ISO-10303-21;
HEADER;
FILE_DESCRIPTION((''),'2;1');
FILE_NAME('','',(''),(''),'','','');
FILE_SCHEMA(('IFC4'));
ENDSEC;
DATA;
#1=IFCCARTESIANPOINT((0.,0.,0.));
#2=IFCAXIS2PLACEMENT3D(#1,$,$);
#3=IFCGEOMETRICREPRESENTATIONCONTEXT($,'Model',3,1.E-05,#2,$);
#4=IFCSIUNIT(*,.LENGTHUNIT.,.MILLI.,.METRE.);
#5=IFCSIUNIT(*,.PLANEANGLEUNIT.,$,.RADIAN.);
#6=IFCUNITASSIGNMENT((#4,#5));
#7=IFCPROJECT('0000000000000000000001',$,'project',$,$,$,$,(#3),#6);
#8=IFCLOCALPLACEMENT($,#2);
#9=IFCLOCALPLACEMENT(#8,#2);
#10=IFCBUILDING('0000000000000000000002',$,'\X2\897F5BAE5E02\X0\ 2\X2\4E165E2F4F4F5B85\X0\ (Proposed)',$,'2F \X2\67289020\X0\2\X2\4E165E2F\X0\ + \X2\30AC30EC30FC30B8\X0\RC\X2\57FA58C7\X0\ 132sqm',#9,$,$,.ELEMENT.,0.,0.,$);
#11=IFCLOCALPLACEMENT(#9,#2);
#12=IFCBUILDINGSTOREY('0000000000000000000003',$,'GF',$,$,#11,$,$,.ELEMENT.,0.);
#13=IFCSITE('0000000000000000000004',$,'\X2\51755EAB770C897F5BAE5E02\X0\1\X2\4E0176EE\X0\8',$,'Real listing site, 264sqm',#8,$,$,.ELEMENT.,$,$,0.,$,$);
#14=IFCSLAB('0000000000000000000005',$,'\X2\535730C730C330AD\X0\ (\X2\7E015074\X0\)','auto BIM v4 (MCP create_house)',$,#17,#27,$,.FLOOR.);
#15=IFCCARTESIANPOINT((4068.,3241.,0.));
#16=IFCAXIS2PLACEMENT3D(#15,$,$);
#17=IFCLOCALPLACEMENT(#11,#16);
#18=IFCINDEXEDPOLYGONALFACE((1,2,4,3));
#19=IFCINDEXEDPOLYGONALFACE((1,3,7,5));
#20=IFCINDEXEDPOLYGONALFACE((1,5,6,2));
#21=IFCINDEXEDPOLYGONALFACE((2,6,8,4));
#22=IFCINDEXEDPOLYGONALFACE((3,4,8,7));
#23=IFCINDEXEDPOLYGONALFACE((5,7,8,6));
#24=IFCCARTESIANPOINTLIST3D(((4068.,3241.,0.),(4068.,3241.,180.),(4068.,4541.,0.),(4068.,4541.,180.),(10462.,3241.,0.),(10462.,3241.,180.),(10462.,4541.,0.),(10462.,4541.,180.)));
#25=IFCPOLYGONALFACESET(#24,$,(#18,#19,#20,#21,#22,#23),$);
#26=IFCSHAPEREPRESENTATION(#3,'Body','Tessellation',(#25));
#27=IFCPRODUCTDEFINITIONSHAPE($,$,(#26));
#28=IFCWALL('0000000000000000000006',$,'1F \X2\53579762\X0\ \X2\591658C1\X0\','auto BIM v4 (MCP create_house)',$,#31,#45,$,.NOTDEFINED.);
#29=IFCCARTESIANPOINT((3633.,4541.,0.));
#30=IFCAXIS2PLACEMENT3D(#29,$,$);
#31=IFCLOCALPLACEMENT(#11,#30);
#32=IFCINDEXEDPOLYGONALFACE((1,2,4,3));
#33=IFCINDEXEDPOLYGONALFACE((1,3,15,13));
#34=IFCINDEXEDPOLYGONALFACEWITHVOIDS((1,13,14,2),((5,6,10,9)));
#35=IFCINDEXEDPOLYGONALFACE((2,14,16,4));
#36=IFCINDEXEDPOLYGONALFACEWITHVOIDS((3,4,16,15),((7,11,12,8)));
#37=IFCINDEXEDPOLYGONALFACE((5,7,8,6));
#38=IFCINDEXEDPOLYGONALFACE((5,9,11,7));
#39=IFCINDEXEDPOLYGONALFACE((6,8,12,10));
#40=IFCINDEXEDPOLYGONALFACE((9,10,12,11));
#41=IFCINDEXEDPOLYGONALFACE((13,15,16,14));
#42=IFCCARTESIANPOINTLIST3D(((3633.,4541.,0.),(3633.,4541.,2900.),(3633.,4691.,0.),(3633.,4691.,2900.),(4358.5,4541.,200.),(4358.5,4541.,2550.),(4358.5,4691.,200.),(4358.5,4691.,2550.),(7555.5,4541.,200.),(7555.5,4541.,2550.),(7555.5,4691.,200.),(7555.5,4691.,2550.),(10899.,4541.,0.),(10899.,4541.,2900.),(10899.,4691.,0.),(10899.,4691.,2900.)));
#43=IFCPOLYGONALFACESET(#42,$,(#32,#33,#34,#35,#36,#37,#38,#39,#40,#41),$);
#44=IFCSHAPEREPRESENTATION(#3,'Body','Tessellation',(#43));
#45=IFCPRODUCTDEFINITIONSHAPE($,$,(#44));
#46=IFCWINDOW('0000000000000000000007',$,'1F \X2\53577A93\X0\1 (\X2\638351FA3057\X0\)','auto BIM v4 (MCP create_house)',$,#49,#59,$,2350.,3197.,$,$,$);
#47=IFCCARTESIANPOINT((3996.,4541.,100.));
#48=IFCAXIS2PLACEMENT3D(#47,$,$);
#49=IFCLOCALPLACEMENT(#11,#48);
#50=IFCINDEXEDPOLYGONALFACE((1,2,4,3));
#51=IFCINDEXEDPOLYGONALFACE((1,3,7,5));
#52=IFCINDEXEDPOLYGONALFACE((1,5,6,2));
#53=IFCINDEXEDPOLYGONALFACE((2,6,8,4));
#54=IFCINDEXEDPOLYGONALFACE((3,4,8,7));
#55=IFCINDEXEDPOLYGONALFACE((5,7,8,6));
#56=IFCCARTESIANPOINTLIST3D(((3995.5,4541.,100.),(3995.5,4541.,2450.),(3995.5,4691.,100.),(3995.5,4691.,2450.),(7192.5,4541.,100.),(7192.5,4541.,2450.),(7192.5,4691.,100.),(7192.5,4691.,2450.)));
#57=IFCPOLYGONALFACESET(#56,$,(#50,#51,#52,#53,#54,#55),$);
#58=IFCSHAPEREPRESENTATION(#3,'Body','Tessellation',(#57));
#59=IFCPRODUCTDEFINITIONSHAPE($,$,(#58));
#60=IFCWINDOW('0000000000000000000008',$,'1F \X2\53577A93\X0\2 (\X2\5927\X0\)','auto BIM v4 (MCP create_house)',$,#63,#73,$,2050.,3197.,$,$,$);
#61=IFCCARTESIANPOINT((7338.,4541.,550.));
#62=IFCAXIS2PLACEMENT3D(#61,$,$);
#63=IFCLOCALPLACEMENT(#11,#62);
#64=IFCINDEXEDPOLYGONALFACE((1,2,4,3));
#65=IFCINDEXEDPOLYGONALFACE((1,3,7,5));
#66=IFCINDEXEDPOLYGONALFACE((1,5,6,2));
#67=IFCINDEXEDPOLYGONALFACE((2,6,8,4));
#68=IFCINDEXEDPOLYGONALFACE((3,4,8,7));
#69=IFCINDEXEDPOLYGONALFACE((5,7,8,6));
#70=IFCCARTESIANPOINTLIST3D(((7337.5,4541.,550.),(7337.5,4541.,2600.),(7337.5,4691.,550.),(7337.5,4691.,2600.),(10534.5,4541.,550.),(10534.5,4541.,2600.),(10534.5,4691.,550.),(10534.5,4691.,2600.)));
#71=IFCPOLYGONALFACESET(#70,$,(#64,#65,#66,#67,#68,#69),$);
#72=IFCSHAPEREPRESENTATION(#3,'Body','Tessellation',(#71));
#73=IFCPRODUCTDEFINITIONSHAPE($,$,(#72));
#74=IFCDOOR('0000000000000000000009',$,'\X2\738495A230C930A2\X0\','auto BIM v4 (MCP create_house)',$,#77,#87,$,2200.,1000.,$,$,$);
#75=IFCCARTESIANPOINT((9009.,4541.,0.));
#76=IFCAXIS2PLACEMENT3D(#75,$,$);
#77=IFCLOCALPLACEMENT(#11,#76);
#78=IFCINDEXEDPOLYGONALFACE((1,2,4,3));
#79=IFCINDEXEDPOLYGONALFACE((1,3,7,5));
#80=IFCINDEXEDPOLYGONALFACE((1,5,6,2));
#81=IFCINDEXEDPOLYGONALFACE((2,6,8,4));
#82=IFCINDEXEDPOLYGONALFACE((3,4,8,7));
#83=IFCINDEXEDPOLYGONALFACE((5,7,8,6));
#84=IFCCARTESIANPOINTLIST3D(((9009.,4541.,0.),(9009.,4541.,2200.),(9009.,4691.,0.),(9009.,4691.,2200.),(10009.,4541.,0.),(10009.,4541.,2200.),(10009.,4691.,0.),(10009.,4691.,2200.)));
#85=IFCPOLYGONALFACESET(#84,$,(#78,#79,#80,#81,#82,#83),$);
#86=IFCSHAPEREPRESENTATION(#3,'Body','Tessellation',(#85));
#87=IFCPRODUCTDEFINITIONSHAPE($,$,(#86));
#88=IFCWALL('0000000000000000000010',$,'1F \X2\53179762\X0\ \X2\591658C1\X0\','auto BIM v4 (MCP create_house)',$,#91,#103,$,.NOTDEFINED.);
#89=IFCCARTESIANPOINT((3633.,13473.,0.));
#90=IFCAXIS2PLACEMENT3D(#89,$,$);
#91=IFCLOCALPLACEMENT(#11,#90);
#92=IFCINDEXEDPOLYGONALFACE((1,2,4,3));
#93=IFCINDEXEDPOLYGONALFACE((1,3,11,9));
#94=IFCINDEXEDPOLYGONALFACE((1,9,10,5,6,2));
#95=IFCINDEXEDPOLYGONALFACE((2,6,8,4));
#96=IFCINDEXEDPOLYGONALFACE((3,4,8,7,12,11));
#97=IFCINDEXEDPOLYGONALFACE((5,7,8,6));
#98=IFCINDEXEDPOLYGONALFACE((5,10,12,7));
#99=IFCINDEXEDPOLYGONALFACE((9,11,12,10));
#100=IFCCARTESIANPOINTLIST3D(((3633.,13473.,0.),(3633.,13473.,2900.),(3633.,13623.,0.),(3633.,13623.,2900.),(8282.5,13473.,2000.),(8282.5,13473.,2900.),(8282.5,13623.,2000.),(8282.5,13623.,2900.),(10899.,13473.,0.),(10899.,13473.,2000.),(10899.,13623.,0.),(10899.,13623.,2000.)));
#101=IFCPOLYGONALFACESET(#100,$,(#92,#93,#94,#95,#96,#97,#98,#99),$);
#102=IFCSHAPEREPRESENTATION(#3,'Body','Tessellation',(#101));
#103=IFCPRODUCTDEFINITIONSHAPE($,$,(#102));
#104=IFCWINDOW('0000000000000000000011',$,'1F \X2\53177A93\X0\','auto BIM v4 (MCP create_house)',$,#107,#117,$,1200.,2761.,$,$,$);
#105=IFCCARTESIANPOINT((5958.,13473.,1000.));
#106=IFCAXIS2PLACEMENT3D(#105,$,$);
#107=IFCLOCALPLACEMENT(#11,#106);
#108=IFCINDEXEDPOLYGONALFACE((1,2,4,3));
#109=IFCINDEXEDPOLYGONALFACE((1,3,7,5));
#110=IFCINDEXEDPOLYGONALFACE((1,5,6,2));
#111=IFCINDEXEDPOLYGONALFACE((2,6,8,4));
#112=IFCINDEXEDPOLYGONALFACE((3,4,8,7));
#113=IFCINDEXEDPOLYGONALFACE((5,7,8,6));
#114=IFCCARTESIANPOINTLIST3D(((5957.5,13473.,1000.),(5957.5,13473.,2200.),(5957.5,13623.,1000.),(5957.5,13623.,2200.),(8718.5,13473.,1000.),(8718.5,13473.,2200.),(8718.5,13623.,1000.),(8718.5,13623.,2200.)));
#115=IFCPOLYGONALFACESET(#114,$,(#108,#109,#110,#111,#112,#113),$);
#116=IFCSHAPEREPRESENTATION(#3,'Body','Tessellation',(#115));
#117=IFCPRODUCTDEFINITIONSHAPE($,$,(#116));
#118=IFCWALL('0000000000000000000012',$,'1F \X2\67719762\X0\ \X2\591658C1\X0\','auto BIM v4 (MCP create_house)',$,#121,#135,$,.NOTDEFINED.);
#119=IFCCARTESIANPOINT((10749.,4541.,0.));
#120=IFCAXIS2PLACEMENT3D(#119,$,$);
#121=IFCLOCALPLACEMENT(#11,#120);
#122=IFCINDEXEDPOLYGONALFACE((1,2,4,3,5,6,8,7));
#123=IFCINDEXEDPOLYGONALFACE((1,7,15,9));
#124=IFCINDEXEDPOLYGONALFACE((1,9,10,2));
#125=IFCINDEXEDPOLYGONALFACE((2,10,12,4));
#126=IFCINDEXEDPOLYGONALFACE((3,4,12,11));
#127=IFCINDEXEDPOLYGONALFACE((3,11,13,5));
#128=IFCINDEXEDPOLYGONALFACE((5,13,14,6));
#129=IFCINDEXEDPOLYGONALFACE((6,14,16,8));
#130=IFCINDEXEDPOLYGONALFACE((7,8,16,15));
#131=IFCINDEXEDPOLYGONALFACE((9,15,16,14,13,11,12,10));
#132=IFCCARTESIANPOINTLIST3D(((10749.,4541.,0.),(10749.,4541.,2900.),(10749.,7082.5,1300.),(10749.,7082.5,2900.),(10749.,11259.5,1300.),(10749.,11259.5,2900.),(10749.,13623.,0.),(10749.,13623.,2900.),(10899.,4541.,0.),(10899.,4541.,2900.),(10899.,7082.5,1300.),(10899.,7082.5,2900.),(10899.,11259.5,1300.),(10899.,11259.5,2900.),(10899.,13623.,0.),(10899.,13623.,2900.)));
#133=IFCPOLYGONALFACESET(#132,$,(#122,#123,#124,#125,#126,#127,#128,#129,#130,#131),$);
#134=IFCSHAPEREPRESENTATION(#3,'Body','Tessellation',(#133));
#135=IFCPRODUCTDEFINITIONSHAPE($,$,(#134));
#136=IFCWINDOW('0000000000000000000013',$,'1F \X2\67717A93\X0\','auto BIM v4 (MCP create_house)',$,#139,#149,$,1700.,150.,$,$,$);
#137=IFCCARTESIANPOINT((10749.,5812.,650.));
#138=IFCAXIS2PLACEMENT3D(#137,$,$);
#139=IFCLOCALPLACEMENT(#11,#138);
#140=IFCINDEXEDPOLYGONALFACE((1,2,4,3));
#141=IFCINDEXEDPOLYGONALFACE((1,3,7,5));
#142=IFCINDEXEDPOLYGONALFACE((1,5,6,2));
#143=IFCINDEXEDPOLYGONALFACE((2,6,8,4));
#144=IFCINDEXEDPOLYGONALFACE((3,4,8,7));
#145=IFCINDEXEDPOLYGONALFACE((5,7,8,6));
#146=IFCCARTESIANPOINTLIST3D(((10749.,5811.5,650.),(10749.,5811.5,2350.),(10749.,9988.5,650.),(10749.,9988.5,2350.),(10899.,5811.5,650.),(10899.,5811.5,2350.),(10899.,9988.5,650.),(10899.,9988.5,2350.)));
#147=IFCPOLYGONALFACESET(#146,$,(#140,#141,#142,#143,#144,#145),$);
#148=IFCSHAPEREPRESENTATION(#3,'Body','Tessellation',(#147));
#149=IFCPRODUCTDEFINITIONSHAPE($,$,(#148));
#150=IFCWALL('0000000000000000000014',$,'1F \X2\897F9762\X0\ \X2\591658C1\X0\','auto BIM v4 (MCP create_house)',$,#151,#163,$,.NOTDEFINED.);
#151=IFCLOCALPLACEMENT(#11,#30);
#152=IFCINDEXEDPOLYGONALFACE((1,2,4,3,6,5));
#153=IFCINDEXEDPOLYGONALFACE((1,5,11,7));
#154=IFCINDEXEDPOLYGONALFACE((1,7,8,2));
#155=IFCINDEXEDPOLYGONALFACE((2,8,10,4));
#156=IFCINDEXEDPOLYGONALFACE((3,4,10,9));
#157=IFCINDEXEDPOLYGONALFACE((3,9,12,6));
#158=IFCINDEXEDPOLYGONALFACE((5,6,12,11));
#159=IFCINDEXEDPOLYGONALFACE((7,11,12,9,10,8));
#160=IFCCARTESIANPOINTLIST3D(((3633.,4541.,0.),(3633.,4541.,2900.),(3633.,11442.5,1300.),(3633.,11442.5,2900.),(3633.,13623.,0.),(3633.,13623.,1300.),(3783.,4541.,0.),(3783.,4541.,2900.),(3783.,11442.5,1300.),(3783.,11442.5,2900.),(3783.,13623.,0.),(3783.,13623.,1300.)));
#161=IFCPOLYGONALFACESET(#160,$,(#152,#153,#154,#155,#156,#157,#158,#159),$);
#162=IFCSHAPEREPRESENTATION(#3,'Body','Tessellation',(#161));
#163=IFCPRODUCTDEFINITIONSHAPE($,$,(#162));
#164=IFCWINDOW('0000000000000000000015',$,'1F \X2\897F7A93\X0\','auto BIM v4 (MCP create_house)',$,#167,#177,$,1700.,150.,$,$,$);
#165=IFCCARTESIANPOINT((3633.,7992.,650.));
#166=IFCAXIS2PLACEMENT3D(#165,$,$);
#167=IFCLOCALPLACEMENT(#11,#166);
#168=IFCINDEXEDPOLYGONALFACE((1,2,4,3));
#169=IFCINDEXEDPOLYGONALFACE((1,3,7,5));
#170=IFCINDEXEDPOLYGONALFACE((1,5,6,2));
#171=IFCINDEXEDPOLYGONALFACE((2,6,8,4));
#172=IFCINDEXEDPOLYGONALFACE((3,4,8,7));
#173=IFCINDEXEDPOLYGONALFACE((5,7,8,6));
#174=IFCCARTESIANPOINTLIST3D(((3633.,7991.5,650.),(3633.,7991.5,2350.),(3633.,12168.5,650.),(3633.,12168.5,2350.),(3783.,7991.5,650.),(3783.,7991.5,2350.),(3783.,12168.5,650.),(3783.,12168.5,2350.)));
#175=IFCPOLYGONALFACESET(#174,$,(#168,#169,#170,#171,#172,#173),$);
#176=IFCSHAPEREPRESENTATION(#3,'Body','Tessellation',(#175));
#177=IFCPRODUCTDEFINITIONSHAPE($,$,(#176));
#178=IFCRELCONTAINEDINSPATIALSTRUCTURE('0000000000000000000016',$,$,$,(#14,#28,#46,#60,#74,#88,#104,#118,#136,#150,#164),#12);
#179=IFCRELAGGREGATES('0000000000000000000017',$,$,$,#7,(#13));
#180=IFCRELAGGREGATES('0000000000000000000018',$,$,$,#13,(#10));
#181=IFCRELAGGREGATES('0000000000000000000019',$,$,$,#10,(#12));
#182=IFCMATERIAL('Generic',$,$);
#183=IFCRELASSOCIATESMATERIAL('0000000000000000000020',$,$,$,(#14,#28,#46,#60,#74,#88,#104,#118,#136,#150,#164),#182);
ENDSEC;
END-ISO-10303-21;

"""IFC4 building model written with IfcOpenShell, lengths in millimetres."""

from ifc_helpers import new_model, si_unit, frame, frame_2d, origin, place, context, project, spatial, rectangle, extrude, material, element, fill, save


model = new_model("IFC4")

# Units and contexts
model_context = context("Model", 3, precision=1e-05, world=origin())
ifc_project = project(units=[si_unit("LENGTHUNIT", "METRE", prefix="MILLI"), si_unit("PLANEANGLEUNIT", "RADIAN")], contexts=[model_context])

# Site, building, storey
site_placement = place(None, origin())
site = spatial("IfcSite", under=ifc_project, at=site_placement, Name="兵庫県西宮市1丁目8", ObjectType="Real listing site, 264sqm", CompositionType="ELEMENT", RefElevation=0.0)
building_placement = place(site_placement, origin())
building = spatial("IfcBuilding", under=site, at=building_placement, Name="西宮市 2世帯住宅 (Proposed)", ObjectType="2F 木造2世帯 + ガレージRC基壇 132sqm", CompositionType="ELEMENT", ElevationOfRefHeight=0.0, ElevationOfTerrain=0.0)
storey_placement = place(building_placement, origin())
storey = spatial("IfcBuildingStorey", under=building, at=storey_placement, Name="GF", CompositionType="ELEMENT", Elevation=0.0)

# Slab
ifc_material = material(Name="Generic")
slab_1_placement = place(storey_placement, frame((4068.0, 3241.0, 0.0)))
element("IfcSlab", 1, at=slab_1_placement, inside=storey, material=ifc_material, Name="南デッキ (縁側)", Description="auto BIM v4 (MCP create_house)", PredefinedType="FLOOR", context=model_context, shape_type="SweptSolid", body=[
    extrude(rectangle(XDim=6394.0, YDim=1300.0, at=frame_2d((3197.0, 650.0))), frame((4068.0, 3241.0, 0.0)), (0.0, 0.0, 1.0), 180.0),
])

# Wall, openings, windows, door
wall_1_placement = place(storey_placement, frame((3633.0, 4541.0, 0.0)))
wall_1 = element("IfcWall", 2, at=wall_1_placement, inside=storey, material=ifc_material, Name="1F 南面 外壁", Description="auto BIM v4 (MCP create_house)", PredefinedType="NOTDEFINED", context=model_context, shape_type="SweptSolid", body=[
    extrude(rectangle(XDim=7266.0, YDim=150.0, at=frame_2d((3633.0, 75.0))), frame((3633.0, 4541.0, 0.0)), (0.0, 0.0, 1.0), 2900.0),
])
opening_1_placement = place(storey_placement, frame((3996.0, 4541.0, 100.0)))
opening_1 = element("IfcOpeningElement", 3, at=opening_1_placement, cuts=wall_1, PredefinedType="NOTDEFINED", context=model_context, shape_type="SweptSolid", body=[
    extrude(rectangle(XDim=3197.0, YDim=150.0, at=frame_2d((1598.0, 75.0))), frame((3996.0, 4541.0, 100.0)), (0.0, 0.0, 1.0), 2350.0),
])
opening_2_placement = place(storey_placement, frame((7338.0, 4541.0, 550.0)))
opening_2 = element("IfcOpeningElement", 4, at=opening_2_placement, cuts=wall_1, PredefinedType="NOTDEFINED", context=model_context, shape_type="SweptSolid", body=[
    extrude(rectangle(XDim=3197.0, YDim=150.0, at=frame_2d((1598.0, 75.0))), frame((7338.0, 4541.0, 550.0)), (0.0, 0.0, 1.0), 2050.0),
])
opening_3_placement = place(storey_placement, frame((9009.0, 4541.0, 0.0)))
opening_3 = element("IfcOpeningElement", 5, at=opening_3_placement, cuts=wall_1, PredefinedType="NOTDEFINED", context=model_context, shape_type="SweptSolid", body=[
    extrude(rectangle(XDim=1000.0, YDim=150.0, at=frame_2d((500.0, 75.0))), frame((9009.0, 4541.0, 0.0)), (0.0, 0.0, 1.0), 2200.0),
])
window_1_placement = place(storey_placement, frame((3996.0, 4541.0, 100.0)))
window_1 = element("IfcWindow", 6, at=window_1_placement, inside=storey, material=ifc_material, Name="1F 南窓1 (掃出し)", Description="auto BIM v4 (MCP create_house)", OverallHeight=2350.0, OverallWidth=3197.0, context=model_context, shape_type="SweptSolid", body=[
    extrude(rectangle(XDim=3197.0, YDim=150.0, at=frame_2d((1598.0, 75.0))), frame((3996.0, 4541.0, 100.0)), (0.0, 0.0, 1.0), 2350.0),
])
fill(opening_1, window_1)
window_2_placement = place(storey_placement, frame((7338.0, 4541.0, 550.0)))
window_2 = element("IfcWindow", 7, at=window_2_placement, inside=storey, material=ifc_material, Name="1F 南窓2 (大)", Description="auto BIM v4 (MCP create_house)", OverallHeight=2050.0, OverallWidth=3197.0, context=model_context, shape_type="SweptSolid", body=[
    extrude(rectangle(XDim=3197.0, YDim=150.0, at=frame_2d((1598.0, 75.0))), frame((7338.0, 4541.0, 550.0)), (0.0, 0.0, 1.0), 2050.0),
])
fill(opening_2, window_2)
door_1_placement = place(storey_placement, frame((9009.0, 4541.0, 0.0)))
door_1 = element("IfcDoor", 8, at=door_1_placement, inside=storey, material=ifc_material, Name="玄関ドア", Description="auto BIM v4 (MCP create_house)", OverallHeight=2200.0, OverallWidth=1000.0, context=model_context, shape_type="SweptSolid", body=[
    extrude(rectangle(XDim=1000.0, YDim=150.0, at=frame_2d((500.0, 75.0))), frame((9009.0, 4541.0, 0.0)), (0.0, 0.0, 1.0), 2200.0),
])
fill(opening_3, door_1)

# Walls, openings, windows
wall_2_placement = place(storey_placement, frame((3633.0, 13473.0, 0.0)))
wall_2 = element("IfcWall", 9, at=wall_2_placement, inside=storey, material=ifc_material, Name="1F 北面 外壁", Description="auto BIM v4 (MCP create_house)", PredefinedType="NOTDEFINED", context=model_context, shape_type="SweptSolid", body=[
    extrude(rectangle(XDim=7266.0, YDim=150.0, at=frame_2d((3633.0, 75.0))), frame((3633.0, 13473.0, 0.0)), (0.0, 0.0, 1.0), 2900.0),
])
opening_4_placement = place(storey_placement, frame((5958.0, 13473.0, 1000.0)))
opening_4 = element("IfcOpeningElement", 10, at=opening_4_placement, cuts=wall_2, PredefinedType="NOTDEFINED", context=model_context, shape_type="SweptSolid", body=[
    extrude(rectangle(XDim=2761.0, YDim=150.0, at=frame_2d((1380.0, 75.0))), frame((5958.0, 13473.0, 1000.0)), (0.0, 0.0, 1.0), 1200.0),
])
window_3_placement = place(storey_placement, frame((5958.0, 13473.0, 1000.0)))
window_3 = element("IfcWindow", 11, at=window_3_placement, inside=storey, material=ifc_material, Name="1F 北窓", Description="auto BIM v4 (MCP create_house)", OverallHeight=1200.0, OverallWidth=2761.0, context=model_context, shape_type="SweptSolid", body=[
    extrude(rectangle(XDim=2761.0, YDim=150.0, at=frame_2d((1380.0, 75.0))), frame((5958.0, 13473.0, 1000.0)), (0.0, 0.0, 1.0), 1200.0),
])
fill(opening_4, window_3)
wall_3_placement = place(storey_placement, frame((10749.0, 4541.0, 0.0)))
wall_3 = element("IfcWall", 12, at=wall_3_placement, inside=storey, material=ifc_material, Name="1F 東面 外壁", Description="auto BIM v4 (MCP create_house)", PredefinedType="NOTDEFINED", context=model_context, shape_type="SweptSolid", body=[
    extrude(rectangle(XDim=150.0, YDim=9082.0, at=frame_2d((75.0, 4541.0))), frame((10749.0, 4541.0, 0.0)), (0.0, 0.0, 1.0), 2900.0),
])
opening_5_placement = place(storey_placement, frame((10749.0, 5812.0, 650.0)))
opening_5 = element("IfcOpeningElement", 13, at=opening_5_placement, cuts=wall_3, PredefinedType="NOTDEFINED", context=model_context, shape_type="SweptSolid", body=[
    extrude(rectangle(XDim=150.0, YDim=4177.0, at=frame_2d((75.0, 2088.0))), frame((10749.0, 5812.0, 650.0)), (0.0, 0.0, 1.0), 1700.0),
])
window_4_placement = place(storey_placement, frame((10749.0, 5812.0, 650.0)))
window_4 = element("IfcWindow", 14, at=window_4_placement, inside=storey, material=ifc_material, Name="1F 東窓", Description="auto BIM v4 (MCP create_house)", OverallHeight=1700.0, OverallWidth=150.0, context=model_context, shape_type="SweptSolid", body=[
    extrude(rectangle(XDim=150.0, YDim=4177.0, at=frame_2d((75.0, 2088.0))), frame((10749.0, 5812.0, 650.0)), (0.0, 0.0, 1.0), 1700.0),
])
fill(opening_5, window_4)
wall_4_placement = place(storey_placement, frame((3633.0, 4541.0, 0.0)))
wall_4 = element("IfcWall", 15, at=wall_4_placement, inside=storey, material=ifc_material, Name="1F 西面 外壁", Description="auto BIM v4 (MCP create_house)", PredefinedType="NOTDEFINED", context=model_context, shape_type="SweptSolid", body=[
    extrude(rectangle(XDim=150.0, YDim=9082.0, at=frame_2d((75.0, 4541.0))), frame((3633.0, 4541.0, 0.0)), (0.0, 0.0, 1.0), 2900.0),
])
opening_6_placement = place(storey_placement, frame((3633.0, 7992.0, 650.0)))
opening_6 = element("IfcOpeningElement", 16, at=opening_6_placement, cuts=wall_4, PredefinedType="NOTDEFINED", context=model_context, shape_type="SweptSolid", body=[
    extrude(rectangle(XDim=150.0, YDim=4177.0, at=frame_2d((75.0, 2088.0))), frame((3633.0, 7992.0, 650.0)), (0.0, 0.0, 1.0), 1700.0),
])
window_5_placement = place(storey_placement, frame((3633.0, 7992.0, 650.0)))
window_5 = element("IfcWindow", 17, at=window_5_placement, inside=storey, material=ifc_material, Name="1F 西窓", Description="auto BIM v4 (MCP create_house)", OverallHeight=1700.0, OverallWidth=150.0, context=model_context, shape_type="SweptSolid", body=[
    extrude(rectangle(XDim=150.0, YDim=4177.0, at=frame_2d((75.0, 2088.0))), frame((3633.0, 7992.0, 650.0)), (0.0, 0.0, 1.0), 1700.0),
])
fill(opening_6, window_5)

save(model, "model.ifc")
